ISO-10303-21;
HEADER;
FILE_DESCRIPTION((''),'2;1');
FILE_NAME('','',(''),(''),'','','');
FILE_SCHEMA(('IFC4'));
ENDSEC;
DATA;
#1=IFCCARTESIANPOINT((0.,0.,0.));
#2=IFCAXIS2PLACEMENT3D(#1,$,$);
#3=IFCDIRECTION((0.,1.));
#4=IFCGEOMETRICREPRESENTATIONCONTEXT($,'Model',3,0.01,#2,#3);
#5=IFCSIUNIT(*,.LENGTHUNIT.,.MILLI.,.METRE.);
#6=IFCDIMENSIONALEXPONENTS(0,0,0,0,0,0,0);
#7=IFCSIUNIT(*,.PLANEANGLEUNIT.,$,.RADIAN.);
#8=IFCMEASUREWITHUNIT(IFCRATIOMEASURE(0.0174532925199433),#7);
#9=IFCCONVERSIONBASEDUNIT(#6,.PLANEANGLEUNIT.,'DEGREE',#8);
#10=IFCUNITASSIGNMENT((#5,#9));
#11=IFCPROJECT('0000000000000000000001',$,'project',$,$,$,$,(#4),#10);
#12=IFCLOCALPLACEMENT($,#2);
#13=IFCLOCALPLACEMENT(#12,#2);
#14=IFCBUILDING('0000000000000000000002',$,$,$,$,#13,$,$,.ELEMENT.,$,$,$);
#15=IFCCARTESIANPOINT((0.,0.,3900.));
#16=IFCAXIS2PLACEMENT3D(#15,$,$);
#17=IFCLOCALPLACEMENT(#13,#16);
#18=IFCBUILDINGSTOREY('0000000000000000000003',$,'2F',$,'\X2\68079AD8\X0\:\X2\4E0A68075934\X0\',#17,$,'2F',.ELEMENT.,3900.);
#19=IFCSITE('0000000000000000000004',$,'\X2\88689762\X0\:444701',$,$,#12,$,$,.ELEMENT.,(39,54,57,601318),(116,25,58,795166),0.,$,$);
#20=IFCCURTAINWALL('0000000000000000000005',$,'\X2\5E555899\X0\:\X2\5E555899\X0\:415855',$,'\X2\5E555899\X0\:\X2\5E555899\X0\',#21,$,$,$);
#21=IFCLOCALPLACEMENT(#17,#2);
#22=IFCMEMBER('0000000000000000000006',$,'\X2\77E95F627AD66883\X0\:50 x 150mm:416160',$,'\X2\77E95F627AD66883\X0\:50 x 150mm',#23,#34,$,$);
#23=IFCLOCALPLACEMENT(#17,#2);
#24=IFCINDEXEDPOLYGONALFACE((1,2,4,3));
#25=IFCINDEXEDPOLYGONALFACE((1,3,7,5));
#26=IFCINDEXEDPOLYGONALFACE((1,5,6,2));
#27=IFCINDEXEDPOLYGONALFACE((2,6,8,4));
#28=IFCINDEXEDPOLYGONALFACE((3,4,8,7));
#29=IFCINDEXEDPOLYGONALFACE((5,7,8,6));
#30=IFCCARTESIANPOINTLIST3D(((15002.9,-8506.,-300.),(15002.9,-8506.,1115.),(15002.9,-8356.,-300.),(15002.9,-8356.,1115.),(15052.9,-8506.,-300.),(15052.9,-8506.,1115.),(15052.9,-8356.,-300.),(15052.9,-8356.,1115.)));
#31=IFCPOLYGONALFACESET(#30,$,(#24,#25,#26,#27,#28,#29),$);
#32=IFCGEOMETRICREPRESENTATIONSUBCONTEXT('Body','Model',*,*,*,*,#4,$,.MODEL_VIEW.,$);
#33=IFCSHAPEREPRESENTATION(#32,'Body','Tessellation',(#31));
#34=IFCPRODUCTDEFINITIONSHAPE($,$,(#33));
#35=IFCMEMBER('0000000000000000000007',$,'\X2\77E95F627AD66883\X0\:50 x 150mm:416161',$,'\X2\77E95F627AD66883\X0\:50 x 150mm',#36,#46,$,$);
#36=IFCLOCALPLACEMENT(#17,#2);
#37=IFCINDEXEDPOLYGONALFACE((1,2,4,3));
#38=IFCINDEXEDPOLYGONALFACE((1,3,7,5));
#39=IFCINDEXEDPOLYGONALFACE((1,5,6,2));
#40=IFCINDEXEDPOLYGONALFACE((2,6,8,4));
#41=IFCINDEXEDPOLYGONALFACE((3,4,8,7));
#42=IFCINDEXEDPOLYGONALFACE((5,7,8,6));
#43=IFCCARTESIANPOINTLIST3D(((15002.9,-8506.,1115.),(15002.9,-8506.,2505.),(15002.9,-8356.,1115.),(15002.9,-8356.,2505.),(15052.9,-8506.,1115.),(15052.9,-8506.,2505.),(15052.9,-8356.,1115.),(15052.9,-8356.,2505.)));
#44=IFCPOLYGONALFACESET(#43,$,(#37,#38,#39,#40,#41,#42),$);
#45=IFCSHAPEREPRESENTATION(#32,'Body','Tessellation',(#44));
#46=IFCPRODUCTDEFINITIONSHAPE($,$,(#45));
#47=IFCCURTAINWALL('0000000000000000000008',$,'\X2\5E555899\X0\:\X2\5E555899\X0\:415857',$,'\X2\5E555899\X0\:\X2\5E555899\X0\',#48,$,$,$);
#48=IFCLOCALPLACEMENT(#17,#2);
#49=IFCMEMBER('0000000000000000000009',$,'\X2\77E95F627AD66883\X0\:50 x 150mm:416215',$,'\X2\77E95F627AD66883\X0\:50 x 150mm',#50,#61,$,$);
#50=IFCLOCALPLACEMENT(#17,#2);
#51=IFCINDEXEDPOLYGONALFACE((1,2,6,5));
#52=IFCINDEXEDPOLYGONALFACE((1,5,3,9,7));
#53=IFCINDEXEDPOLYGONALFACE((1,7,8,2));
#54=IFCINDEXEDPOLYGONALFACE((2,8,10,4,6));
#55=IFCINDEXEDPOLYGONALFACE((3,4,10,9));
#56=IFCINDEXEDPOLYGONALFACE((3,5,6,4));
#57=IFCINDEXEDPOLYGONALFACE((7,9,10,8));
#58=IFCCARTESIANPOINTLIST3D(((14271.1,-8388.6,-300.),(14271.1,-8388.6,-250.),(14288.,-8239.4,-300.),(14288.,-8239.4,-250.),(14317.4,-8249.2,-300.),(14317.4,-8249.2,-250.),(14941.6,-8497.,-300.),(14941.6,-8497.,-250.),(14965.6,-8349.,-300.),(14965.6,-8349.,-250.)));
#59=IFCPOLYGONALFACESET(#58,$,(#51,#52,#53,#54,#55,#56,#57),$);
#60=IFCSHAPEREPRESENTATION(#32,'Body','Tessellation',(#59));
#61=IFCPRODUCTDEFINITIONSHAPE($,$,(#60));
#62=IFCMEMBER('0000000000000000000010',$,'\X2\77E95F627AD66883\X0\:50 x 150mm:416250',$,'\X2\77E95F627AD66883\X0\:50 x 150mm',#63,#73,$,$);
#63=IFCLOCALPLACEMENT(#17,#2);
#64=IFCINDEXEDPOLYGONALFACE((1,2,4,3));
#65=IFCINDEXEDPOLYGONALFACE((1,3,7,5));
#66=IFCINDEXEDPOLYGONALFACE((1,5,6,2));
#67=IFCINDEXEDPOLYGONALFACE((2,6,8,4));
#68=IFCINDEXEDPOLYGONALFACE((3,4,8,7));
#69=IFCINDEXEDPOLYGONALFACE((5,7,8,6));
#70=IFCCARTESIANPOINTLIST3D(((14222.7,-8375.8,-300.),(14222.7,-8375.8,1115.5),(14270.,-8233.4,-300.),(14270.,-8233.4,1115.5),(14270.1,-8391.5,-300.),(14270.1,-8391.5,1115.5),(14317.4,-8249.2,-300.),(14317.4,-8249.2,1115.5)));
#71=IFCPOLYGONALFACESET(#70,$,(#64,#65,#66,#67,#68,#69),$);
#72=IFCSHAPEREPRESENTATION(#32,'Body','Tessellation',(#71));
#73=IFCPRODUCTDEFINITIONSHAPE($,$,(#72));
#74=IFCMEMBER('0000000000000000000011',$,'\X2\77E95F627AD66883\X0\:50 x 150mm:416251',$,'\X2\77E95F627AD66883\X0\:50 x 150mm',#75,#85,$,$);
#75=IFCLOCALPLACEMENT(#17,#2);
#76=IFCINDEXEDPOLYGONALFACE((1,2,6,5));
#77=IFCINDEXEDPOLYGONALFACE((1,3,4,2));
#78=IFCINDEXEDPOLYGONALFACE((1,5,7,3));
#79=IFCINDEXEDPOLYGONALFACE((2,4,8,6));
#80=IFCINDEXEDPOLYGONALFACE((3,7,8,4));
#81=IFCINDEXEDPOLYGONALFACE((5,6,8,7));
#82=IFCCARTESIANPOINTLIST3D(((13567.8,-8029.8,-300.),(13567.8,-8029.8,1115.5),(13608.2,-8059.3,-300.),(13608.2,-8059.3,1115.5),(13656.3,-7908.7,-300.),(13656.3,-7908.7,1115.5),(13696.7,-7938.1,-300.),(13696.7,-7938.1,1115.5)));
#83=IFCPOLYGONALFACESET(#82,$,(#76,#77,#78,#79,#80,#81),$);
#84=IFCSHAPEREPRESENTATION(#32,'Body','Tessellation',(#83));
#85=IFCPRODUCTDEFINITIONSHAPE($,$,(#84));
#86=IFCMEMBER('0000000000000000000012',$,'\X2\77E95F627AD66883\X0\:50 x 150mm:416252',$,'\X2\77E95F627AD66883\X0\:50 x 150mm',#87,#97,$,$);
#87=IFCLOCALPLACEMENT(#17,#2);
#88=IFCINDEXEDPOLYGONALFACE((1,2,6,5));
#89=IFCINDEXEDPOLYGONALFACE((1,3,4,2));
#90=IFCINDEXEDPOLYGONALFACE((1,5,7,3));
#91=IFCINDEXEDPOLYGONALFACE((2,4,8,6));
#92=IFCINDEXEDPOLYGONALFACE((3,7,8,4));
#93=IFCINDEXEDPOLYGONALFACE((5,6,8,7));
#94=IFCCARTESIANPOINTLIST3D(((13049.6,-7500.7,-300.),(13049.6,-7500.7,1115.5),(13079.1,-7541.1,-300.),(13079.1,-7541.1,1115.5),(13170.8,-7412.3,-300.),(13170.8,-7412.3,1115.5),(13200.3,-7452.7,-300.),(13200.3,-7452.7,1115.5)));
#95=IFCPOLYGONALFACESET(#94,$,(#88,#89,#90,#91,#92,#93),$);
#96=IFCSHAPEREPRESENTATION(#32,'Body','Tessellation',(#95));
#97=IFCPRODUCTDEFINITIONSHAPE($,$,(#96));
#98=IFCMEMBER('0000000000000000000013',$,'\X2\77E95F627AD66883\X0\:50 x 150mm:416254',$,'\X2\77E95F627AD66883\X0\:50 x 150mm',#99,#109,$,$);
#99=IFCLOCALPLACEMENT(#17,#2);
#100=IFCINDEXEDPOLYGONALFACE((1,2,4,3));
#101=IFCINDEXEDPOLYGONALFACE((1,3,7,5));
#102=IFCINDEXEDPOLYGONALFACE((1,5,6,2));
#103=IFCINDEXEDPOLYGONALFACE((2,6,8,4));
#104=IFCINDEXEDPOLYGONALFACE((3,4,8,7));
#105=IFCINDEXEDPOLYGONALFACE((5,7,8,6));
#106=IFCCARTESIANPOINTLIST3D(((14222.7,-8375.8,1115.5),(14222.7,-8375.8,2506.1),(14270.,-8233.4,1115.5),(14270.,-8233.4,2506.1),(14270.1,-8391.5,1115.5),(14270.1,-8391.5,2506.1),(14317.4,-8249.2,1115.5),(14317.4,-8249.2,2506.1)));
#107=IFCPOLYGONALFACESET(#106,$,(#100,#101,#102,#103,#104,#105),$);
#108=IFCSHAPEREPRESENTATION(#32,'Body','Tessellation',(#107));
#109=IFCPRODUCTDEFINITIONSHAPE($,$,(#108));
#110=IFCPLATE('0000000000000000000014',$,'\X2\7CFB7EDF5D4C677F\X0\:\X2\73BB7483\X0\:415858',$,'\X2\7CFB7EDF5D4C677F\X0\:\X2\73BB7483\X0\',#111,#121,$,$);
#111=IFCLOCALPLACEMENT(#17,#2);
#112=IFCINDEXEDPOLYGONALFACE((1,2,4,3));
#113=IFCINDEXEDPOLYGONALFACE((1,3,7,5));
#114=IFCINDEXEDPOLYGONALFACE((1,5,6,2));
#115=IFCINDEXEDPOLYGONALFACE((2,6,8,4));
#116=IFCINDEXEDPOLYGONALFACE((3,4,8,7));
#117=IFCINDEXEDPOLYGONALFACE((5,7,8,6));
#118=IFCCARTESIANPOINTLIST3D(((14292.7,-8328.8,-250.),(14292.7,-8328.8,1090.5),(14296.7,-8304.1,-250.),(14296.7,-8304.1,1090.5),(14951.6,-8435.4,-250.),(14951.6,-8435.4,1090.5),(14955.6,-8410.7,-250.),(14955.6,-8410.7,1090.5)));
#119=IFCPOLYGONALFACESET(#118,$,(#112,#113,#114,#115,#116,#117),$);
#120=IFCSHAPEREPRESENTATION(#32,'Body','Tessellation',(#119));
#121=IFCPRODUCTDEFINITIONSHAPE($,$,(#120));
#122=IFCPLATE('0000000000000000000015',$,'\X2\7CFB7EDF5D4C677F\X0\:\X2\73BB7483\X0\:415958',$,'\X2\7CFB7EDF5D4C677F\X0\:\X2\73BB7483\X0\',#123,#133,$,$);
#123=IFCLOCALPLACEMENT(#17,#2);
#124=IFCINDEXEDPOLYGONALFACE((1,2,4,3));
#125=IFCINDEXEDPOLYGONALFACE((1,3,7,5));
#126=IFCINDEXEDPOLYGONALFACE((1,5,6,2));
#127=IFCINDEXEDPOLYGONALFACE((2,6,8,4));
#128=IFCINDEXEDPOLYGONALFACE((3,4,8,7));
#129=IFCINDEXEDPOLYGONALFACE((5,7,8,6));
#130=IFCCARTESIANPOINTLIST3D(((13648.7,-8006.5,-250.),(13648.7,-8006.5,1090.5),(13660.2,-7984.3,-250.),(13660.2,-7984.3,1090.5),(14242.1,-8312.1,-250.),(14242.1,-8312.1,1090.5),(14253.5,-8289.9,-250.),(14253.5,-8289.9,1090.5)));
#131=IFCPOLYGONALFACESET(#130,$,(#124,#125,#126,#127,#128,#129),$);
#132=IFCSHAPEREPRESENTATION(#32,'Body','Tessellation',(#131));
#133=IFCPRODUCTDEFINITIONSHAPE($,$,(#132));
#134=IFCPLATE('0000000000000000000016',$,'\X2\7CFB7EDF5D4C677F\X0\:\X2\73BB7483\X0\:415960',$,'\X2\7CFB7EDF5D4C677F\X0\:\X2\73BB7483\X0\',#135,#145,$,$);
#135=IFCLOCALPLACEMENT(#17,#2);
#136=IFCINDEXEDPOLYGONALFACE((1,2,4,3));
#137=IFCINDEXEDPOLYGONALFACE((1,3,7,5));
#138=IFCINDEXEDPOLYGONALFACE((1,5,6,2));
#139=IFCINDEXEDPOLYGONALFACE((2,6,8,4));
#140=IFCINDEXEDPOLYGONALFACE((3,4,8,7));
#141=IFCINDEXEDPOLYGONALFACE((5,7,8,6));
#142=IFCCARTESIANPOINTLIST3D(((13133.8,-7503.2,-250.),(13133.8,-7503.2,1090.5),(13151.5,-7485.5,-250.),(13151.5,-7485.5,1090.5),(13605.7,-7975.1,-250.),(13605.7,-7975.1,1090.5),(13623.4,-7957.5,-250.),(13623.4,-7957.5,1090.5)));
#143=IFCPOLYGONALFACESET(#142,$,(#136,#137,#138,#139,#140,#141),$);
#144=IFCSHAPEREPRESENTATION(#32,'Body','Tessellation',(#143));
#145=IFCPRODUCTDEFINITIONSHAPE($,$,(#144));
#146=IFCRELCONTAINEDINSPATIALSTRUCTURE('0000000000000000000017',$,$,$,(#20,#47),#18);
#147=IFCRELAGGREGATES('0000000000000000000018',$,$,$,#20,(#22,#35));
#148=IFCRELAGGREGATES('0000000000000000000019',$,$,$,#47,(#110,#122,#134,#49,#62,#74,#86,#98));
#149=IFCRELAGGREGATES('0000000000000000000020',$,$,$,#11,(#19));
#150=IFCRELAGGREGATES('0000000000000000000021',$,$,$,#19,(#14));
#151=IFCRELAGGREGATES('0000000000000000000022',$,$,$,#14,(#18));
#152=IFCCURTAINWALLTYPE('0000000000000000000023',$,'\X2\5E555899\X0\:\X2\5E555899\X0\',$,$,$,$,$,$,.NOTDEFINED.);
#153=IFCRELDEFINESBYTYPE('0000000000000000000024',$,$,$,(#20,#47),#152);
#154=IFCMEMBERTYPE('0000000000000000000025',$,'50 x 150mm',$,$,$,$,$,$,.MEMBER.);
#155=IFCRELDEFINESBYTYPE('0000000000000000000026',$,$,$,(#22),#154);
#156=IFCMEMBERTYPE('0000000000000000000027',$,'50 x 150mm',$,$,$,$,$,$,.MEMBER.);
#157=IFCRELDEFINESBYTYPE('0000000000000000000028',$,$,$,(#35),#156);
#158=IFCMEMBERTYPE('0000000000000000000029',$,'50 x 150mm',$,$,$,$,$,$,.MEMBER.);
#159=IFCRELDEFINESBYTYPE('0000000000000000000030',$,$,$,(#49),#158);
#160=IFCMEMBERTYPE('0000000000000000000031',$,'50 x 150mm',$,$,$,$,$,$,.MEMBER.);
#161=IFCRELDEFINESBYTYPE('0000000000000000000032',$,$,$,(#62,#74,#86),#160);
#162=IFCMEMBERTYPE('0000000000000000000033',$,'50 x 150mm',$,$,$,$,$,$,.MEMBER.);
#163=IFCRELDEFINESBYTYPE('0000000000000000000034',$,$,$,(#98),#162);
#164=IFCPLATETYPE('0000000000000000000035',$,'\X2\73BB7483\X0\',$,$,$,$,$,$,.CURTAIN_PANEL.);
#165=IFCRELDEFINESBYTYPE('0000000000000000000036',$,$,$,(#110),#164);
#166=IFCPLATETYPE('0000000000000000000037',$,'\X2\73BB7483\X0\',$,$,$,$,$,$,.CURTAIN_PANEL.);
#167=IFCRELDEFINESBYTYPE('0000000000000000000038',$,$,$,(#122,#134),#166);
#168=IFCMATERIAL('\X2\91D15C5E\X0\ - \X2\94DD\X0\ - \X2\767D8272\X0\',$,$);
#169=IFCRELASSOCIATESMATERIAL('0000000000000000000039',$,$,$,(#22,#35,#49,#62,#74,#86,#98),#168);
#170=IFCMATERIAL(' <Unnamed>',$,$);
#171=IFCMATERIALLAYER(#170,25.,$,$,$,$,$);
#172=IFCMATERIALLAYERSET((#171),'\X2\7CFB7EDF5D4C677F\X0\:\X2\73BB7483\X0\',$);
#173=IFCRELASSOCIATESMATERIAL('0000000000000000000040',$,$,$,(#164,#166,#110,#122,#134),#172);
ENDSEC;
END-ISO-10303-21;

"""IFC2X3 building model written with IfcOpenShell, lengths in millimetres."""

from ifc_helpers import new_model, entity, si_unit, converted_unit, direction, frame, frame_2d, origin, origin_2d_with_axis, place, context, subcontext, project, spatial, polyline, rectangle, extrude, clip, bounded_halfspace, source, transform, mapped, material, layer, layer_set, layer_usage, type_object, type_shapes, element, aggregate, save


model = new_model("IFC2X3")

# Units and contexts
model_context = context("Model", 3, precision=0.01, world=origin(), true_north=direction((0.0, 1.0)))
body_context = subcontext(model_context, "Body", "Model", "MODEL_VIEW")
ifc_project = project(units=[si_unit("LENGTHUNIT", "METRE", prefix="MILLI"), converted_unit("PLANEANGLEUNIT", "DEGREE", entity("IfcRatioMeasure", 0.0174532925199433), si_unit("PLANEANGLEUNIT", "RADIAN"), dimensions=[0, 0, 0, 0, 0, 0, 0])], contexts=[model_context])

# Site, building, storey
site_placement = place(None, origin())
site = spatial("IfcSite", under=ifc_project, at=site_placement, Name="表面:444701", CompositionType="ELEMENT", RefLatitude=(39, 54, 57, 601318), RefLongitude=(116, 25, 58, 795166), RefElevation=0.0)
building_placement = place(site_placement, origin())
building = spatial("IfcBuilding", under=site, at=building_placement, CompositionType="ELEMENT")
storey_placement = place(building_placement, frame((0.0, 0.0, 3900.0)))
storey = spatial("IfcBuildingStorey", under=building, at=storey_placement, Name="2F", ObjectType="标高:上标头", LongName="2F", CompositionType="ELEMENT", Elevation=3900.0)

# Curtain wall, members
curtain_wall_type = type_object("IfcCurtainWallType", Name="幕墙:幕墙", PredefinedType="NOTDEFINED")
curtain_wall_1_placement = place(storey_placement, frame((0.0, 0.0, -3900.0)))
curtain_wall_1 = element("IfcCurtainWall", 1, at=curtain_wall_1_placement, inside=storey, type_object=curtain_wall_type, Name="幕墙:幕墙:415855", ObjectType="幕墙:幕墙")
ifc_material_1 = material(Name="金属 - 铝 - 白色")
member_type_1 = type_object("IfcMemberType", Name="50 x 150mm", PredefinedType="MEMBER")
shared_shape_1 = source(origin(), body_context, "Body", "SweptSolid", [
    extrude(rectangle(XDim=150.0, YDim=50.0, at=origin_2d_with_axis()), frame((-25.0, 0.0, -1415.0), z_axis=(0.0, 0.0, 1.0), x_axis=(0.0, -1.0, 0.0)), (0.0, 0.0, 1.0), 1415.0),
])
type_shapes(member_type_1, [shared_shape_1])
member_1_placement = place(storey_placement, frame((15002.9, -8431.0, -300.0), z_axis=(0.0, 0.0, -1.0), x_axis=(-1.0, 0.0, 0.0)))
member_1 = element("IfcMember", 2, at=member_1_placement, type_object=member_type_1, material=ifc_material_1, Name="矩形竖梃:50 x 150mm:416160", ObjectType="矩形竖梃:50 x 150mm", context=body_context, shape_type="MappedRepresentation", body=[
    mapped(shared_shape_1, transform((0.0, 0.0, 0.0), scale=1.0)),
])
member_type_2 = type_object("IfcMemberType", Name="50 x 150mm", PredefinedType="MEMBER")
shared_shape_2 = source(origin(), body_context, "Body", "SweptSolid", [
    extrude(rectangle(XDim=150.0, YDim=50.0, at=origin_2d_with_axis()), frame((-25.0, 0.0, -1390.0), z_axis=(0.0, 0.0, 1.0), x_axis=(0.0, -1.0, 0.0)), (0.0, 0.0, 1.0), 1390.0),
])
type_shapes(member_type_2, [shared_shape_2])
member_2_placement = place(storey_placement, frame((15002.9, -8431.0, 1115.0), z_axis=(0.0, 0.0, -1.0), x_axis=(-1.0, 0.0, 0.0)))
member_2 = element("IfcMember", 3, at=member_2_placement, type_object=member_type_2, material=ifc_material_1, Name="矩形竖梃:50 x 150mm:416161", ObjectType="矩形竖梃:50 x 150mm", context=body_context, shape_type="MappedRepresentation", body=[
    mapped(shared_shape_2, transform((0.0, 0.0, 0.0), scale=1.0)),
])
aggregate(curtain_wall_1, [member_1, member_2])

# Curtain wall, member
curtain_wall_2_placement = place(storey_placement, frame((0.0, 0.0, -3900.0)))
curtain_wall_2 = element("IfcCurtainWall", 4, at=curtain_wall_2_placement, inside=storey, type_object=curtain_wall_type, Name="幕墙:幕墙:415857", ObjectType="幕墙:幕墙")
member_type_3 = type_object("IfcMemberType", Name="50 x 150mm", PredefinedType="MEMBER")
shared_shape_3 = source(origin(), body_context, "Body", "Clipping", [
    clip(clip(extrude(rectangle(XDim=50.0, YDim=150.0, at=origin_2d_with_axis()), frame((-25.0, 0.0, -686.4)), (0.0, 0.0, 1.0), 686.4), bounded_halfspace(frame((0.0, 70.0, -655.8), z_axis=(0.0, 0.15966, -0.987172), x_axis=(-1.0, 0.0, 0.0)), False, frame((-25.0, 0.0, -686.4)), polyline([(25.0, 70.0), (25.0, -75.0), (-25.0, -75.0), (-25.0, 70.0), (25.0, 70.0)]))), bounded_halfspace(frame((0.0, 78.0, -705.1), z_axis=(0.0, -0.987172, -0.15966), x_axis=(-1.0, 0.0, 0.0)), False, frame((-25.0, 0.0, -686.4)), polyline([(25.0, 75.0), (25.0, 70.0), (-25.0, 70.0), (-25.0, 75.0), (25.0, 75.0)]))),
])
type_shapes(member_type_3, [shared_shape_3])
member_3_placement = place(storey_placement, frame((14953.6, -8423.0, -300.0), z_axis=(0.987172, -0.15966, 0.0), x_axis=(0.0, 0.0, -1.0)))
member_3 = element("IfcMember", 5, at=member_3_placement, type_object=member_type_3, material=ifc_material_1, Name="矩形竖梃:50 x 150mm:416215", ObjectType="矩形竖梃:50 x 150mm", context=body_context, shape_type="MappedRepresentation", body=[
    mapped(shared_shape_3, transform((0.0, 0.0, 0.0), scale=1.0)),
])

# Members
member_type_4 = type_object("IfcMemberType", Name="50 x 150mm", PredefinedType="MEMBER")
shared_shape_4 = source(origin(), body_context, "Body", "SweptSolid", [
    extrude(rectangle(XDim=150.0, YDim=50.0, at=origin_2d_with_axis()), frame((0.0, 0.0, -1415.5), z_axis=(0.0, 0.0, 1.0), x_axis=(0.0, -1.0, 0.0)), (0.0, 0.0, 1.0), 1415.5),
])
type_shapes(member_type_4, [shared_shape_4])
member_4_placement = place(storey_placement, frame((14270.0, -8312.5, -300.0), z_axis=(0.0, 0.0, -1.0), x_axis=(-0.949018, 0.315223, 0.0)))
member_4 = element("IfcMember", 6, at=member_4_placement, type_object=member_type_4, material=ifc_material_1, Name="矩形竖梃:50 x 150mm:416250", ObjectType="矩形竖梃:50 x 150mm", context=body_context, shape_type="MappedRepresentation", body=[
    mapped(shared_shape_4, transform((0.0, 0.0, 0.0), scale=1.0)),
])
member_5_placement = place(storey_placement, frame((13632.2, -7984.0, -300.0), z_axis=(0.0, 0.0, -1.0), x_axis=(-0.807735, 0.589546, 0.0)))
member_5 = element("IfcMember", 7, at=member_5_placement, type_object=member_type_4, material=ifc_material_1, Name="矩形竖梃:50 x 150mm:416251", ObjectType="矩形竖梃:50 x 150mm", context=body_context, shape_type="MappedRepresentation", body=[
    mapped(shared_shape_4, transform((0.0, 0.0, 0.0), scale=1.0)),
])
member_6_placement = place(storey_placement, frame((13125.0, -7476.7, -300.0), z_axis=(0.0, 0.0, -1.0), x_axis=(-0.589546, 0.807735, 0.0)))
member_6 = element("IfcMember", 8, at=member_6_placement, type_object=member_type_4, material=ifc_material_1, Name="矩形竖梃:50 x 150mm:416252", ObjectType="矩形竖梃:50 x 150mm", context=body_context, shape_type="MappedRepresentation", body=[
    mapped(shared_shape_4, transform((0.0, 0.0, 0.0), scale=1.0)),
])
member_type_5 = type_object("IfcMemberType", Name="50 x 150mm", PredefinedType="MEMBER")
shared_shape_5 = source(origin(), body_context, "Body", "SweptSolid", [
    extrude(rectangle(XDim=150.0, YDim=50.0, at=origin_2d_with_axis()), frame((0.0, 0.0, -1390.5), z_axis=(0.0, 0.0, 1.0), x_axis=(0.0, -1.0, 0.0)), (0.0, 0.0, 1.0), 1390.5),
])
type_shapes(member_type_5, [shared_shape_5])
member_7_placement = place(storey_placement, frame((14270.0, -8312.5, 1115.5), z_axis=(0.0, 0.0, -1.0), x_axis=(-0.949018, 0.315223, 0.0)))
member_7 = element("IfcMember", 9, at=member_7_placement, type_object=member_type_5, material=ifc_material_1, Name="矩形竖梃:50 x 150mm:416254", ObjectType="矩形竖梃:50 x 150mm", context=body_context, shape_type="MappedRepresentation", body=[
    mapped(shared_shape_5, transform((0.0, 0.0, 0.0), scale=1.0)),
])

# Plates
ifc_material_2 = material(Name=" <Unnamed>")
ifc_layer = layer(ifc_material_2, 25.0)
ifc_layer_set = layer_set([ifc_layer], Name="系统嵌板:玻璃")
ifc_layer_usage_1 = layer_usage(ifc_layer_set, "AXIS3", "POSITIVE", 0.0)
plate_type_1 = type_object("IfcPlateType", Name="玻璃", PredefinedType="CURTAIN_PANEL", material=ifc_layer_set)
shared_shape_6 = source(origin(), body_context, "Body", "SweptSolid", [
    extrude(rectangle(XDim=25.0, YDim=667.4, at=frame_2d((0.0, 0.0), x_axis=(1.0, 0.0))), frame((0.0, 0.0, 0.0), z_axis=(0.0, 0.0, 1.0), x_axis=(0.0, 1.0, 0.0)), (0.0, 0.0, 1.0), 1340.5),
])
type_shapes(plate_type_1, [shared_shape_6])
plate_1_placement = place(curtain_wall_2_placement, frame((14624.2, -8369.7, 3650.0), z_axis=(0.0, 0.0, 1.0), x_axis=(-0.987172, 0.15966, 0.0)))
plate_1 = element("IfcPlate", 10, at=plate_1_placement, type_object=plate_type_1, material=ifc_layer_usage_1, Name="系统嵌板:玻璃:415858", ObjectType="系统嵌板:玻璃", context=body_context, shape_type="MappedRepresentation", body=[
    mapped(shared_shape_6, transform((0.0, 0.0, 0.0), scale=1.0)),
])
ifc_layer_usage_2 = layer_usage(ifc_layer_set, "AXIS3", "POSITIVE", 0.0)
plate_type_2 = type_object("IfcPlateType", Name="玻璃", PredefinedType="CURTAIN_PANEL", material=ifc_layer_set)
shared_shape_7 = source(origin(), body_context, "Body", "SweptSolid", [
    extrude(rectangle(XDim=25.0, YDim=667.4, at=frame_2d((0.0, 0.0), x_axis=(1.0, 0.0))), frame((0.0, 0.0, 0.0), z_axis=(0.0, 0.0, 1.0), x_axis=(0.0, 1.0, 0.0)), (0.0, 0.0, 1.0), 1340.5),
])
type_shapes(plate_type_2, [shared_shape_7])
plate_2_placement = place(curtain_wall_2_placement, frame((13951.1, -8148.2, 3650.0), z_axis=(0.0, 0.0, 1.0), x_axis=(-0.889021, 0.457867, 0.0)))
plate_2 = element("IfcPlate", 11, at=plate_2_placement, type_object=plate_type_2, material=ifc_layer_usage_2, Name="系统嵌板:玻璃:415958", ObjectType="系统嵌板:玻璃", context=body_context, shape_type="MappedRepresentation", body=[
    mapped(shared_shape_7, transform((0.0, 0.0, 0.0), scale=1.0)),
])
ifc_layer_usage_3 = layer_usage(ifc_layer_set, "AXIS3", "POSITIVE", 0.0)
plate_3_placement = place(curtain_wall_2_placement, frame((13378.6, -7730.3, 3650.0), z_axis=(0.0, 0.0, 1.0), x_axis=(-0.707107, 0.707107, 0.0)))
plate_3 = element("IfcPlate", 12, at=plate_3_placement, type_object=plate_type_2, material=ifc_layer_usage_3, Name="系统嵌板:玻璃:415960", ObjectType="系统嵌板:玻璃", context=body_context, shape_type="MappedRepresentation", body=[
    mapped(shared_shape_7, transform((0.0, 0.0, 0.0), scale=1.0)),
])
aggregate(curtain_wall_2, [plate_1, plate_2, plate_3, member_3, member_4, member_5, member_6, member_7])

save(model, "model.ifc")
